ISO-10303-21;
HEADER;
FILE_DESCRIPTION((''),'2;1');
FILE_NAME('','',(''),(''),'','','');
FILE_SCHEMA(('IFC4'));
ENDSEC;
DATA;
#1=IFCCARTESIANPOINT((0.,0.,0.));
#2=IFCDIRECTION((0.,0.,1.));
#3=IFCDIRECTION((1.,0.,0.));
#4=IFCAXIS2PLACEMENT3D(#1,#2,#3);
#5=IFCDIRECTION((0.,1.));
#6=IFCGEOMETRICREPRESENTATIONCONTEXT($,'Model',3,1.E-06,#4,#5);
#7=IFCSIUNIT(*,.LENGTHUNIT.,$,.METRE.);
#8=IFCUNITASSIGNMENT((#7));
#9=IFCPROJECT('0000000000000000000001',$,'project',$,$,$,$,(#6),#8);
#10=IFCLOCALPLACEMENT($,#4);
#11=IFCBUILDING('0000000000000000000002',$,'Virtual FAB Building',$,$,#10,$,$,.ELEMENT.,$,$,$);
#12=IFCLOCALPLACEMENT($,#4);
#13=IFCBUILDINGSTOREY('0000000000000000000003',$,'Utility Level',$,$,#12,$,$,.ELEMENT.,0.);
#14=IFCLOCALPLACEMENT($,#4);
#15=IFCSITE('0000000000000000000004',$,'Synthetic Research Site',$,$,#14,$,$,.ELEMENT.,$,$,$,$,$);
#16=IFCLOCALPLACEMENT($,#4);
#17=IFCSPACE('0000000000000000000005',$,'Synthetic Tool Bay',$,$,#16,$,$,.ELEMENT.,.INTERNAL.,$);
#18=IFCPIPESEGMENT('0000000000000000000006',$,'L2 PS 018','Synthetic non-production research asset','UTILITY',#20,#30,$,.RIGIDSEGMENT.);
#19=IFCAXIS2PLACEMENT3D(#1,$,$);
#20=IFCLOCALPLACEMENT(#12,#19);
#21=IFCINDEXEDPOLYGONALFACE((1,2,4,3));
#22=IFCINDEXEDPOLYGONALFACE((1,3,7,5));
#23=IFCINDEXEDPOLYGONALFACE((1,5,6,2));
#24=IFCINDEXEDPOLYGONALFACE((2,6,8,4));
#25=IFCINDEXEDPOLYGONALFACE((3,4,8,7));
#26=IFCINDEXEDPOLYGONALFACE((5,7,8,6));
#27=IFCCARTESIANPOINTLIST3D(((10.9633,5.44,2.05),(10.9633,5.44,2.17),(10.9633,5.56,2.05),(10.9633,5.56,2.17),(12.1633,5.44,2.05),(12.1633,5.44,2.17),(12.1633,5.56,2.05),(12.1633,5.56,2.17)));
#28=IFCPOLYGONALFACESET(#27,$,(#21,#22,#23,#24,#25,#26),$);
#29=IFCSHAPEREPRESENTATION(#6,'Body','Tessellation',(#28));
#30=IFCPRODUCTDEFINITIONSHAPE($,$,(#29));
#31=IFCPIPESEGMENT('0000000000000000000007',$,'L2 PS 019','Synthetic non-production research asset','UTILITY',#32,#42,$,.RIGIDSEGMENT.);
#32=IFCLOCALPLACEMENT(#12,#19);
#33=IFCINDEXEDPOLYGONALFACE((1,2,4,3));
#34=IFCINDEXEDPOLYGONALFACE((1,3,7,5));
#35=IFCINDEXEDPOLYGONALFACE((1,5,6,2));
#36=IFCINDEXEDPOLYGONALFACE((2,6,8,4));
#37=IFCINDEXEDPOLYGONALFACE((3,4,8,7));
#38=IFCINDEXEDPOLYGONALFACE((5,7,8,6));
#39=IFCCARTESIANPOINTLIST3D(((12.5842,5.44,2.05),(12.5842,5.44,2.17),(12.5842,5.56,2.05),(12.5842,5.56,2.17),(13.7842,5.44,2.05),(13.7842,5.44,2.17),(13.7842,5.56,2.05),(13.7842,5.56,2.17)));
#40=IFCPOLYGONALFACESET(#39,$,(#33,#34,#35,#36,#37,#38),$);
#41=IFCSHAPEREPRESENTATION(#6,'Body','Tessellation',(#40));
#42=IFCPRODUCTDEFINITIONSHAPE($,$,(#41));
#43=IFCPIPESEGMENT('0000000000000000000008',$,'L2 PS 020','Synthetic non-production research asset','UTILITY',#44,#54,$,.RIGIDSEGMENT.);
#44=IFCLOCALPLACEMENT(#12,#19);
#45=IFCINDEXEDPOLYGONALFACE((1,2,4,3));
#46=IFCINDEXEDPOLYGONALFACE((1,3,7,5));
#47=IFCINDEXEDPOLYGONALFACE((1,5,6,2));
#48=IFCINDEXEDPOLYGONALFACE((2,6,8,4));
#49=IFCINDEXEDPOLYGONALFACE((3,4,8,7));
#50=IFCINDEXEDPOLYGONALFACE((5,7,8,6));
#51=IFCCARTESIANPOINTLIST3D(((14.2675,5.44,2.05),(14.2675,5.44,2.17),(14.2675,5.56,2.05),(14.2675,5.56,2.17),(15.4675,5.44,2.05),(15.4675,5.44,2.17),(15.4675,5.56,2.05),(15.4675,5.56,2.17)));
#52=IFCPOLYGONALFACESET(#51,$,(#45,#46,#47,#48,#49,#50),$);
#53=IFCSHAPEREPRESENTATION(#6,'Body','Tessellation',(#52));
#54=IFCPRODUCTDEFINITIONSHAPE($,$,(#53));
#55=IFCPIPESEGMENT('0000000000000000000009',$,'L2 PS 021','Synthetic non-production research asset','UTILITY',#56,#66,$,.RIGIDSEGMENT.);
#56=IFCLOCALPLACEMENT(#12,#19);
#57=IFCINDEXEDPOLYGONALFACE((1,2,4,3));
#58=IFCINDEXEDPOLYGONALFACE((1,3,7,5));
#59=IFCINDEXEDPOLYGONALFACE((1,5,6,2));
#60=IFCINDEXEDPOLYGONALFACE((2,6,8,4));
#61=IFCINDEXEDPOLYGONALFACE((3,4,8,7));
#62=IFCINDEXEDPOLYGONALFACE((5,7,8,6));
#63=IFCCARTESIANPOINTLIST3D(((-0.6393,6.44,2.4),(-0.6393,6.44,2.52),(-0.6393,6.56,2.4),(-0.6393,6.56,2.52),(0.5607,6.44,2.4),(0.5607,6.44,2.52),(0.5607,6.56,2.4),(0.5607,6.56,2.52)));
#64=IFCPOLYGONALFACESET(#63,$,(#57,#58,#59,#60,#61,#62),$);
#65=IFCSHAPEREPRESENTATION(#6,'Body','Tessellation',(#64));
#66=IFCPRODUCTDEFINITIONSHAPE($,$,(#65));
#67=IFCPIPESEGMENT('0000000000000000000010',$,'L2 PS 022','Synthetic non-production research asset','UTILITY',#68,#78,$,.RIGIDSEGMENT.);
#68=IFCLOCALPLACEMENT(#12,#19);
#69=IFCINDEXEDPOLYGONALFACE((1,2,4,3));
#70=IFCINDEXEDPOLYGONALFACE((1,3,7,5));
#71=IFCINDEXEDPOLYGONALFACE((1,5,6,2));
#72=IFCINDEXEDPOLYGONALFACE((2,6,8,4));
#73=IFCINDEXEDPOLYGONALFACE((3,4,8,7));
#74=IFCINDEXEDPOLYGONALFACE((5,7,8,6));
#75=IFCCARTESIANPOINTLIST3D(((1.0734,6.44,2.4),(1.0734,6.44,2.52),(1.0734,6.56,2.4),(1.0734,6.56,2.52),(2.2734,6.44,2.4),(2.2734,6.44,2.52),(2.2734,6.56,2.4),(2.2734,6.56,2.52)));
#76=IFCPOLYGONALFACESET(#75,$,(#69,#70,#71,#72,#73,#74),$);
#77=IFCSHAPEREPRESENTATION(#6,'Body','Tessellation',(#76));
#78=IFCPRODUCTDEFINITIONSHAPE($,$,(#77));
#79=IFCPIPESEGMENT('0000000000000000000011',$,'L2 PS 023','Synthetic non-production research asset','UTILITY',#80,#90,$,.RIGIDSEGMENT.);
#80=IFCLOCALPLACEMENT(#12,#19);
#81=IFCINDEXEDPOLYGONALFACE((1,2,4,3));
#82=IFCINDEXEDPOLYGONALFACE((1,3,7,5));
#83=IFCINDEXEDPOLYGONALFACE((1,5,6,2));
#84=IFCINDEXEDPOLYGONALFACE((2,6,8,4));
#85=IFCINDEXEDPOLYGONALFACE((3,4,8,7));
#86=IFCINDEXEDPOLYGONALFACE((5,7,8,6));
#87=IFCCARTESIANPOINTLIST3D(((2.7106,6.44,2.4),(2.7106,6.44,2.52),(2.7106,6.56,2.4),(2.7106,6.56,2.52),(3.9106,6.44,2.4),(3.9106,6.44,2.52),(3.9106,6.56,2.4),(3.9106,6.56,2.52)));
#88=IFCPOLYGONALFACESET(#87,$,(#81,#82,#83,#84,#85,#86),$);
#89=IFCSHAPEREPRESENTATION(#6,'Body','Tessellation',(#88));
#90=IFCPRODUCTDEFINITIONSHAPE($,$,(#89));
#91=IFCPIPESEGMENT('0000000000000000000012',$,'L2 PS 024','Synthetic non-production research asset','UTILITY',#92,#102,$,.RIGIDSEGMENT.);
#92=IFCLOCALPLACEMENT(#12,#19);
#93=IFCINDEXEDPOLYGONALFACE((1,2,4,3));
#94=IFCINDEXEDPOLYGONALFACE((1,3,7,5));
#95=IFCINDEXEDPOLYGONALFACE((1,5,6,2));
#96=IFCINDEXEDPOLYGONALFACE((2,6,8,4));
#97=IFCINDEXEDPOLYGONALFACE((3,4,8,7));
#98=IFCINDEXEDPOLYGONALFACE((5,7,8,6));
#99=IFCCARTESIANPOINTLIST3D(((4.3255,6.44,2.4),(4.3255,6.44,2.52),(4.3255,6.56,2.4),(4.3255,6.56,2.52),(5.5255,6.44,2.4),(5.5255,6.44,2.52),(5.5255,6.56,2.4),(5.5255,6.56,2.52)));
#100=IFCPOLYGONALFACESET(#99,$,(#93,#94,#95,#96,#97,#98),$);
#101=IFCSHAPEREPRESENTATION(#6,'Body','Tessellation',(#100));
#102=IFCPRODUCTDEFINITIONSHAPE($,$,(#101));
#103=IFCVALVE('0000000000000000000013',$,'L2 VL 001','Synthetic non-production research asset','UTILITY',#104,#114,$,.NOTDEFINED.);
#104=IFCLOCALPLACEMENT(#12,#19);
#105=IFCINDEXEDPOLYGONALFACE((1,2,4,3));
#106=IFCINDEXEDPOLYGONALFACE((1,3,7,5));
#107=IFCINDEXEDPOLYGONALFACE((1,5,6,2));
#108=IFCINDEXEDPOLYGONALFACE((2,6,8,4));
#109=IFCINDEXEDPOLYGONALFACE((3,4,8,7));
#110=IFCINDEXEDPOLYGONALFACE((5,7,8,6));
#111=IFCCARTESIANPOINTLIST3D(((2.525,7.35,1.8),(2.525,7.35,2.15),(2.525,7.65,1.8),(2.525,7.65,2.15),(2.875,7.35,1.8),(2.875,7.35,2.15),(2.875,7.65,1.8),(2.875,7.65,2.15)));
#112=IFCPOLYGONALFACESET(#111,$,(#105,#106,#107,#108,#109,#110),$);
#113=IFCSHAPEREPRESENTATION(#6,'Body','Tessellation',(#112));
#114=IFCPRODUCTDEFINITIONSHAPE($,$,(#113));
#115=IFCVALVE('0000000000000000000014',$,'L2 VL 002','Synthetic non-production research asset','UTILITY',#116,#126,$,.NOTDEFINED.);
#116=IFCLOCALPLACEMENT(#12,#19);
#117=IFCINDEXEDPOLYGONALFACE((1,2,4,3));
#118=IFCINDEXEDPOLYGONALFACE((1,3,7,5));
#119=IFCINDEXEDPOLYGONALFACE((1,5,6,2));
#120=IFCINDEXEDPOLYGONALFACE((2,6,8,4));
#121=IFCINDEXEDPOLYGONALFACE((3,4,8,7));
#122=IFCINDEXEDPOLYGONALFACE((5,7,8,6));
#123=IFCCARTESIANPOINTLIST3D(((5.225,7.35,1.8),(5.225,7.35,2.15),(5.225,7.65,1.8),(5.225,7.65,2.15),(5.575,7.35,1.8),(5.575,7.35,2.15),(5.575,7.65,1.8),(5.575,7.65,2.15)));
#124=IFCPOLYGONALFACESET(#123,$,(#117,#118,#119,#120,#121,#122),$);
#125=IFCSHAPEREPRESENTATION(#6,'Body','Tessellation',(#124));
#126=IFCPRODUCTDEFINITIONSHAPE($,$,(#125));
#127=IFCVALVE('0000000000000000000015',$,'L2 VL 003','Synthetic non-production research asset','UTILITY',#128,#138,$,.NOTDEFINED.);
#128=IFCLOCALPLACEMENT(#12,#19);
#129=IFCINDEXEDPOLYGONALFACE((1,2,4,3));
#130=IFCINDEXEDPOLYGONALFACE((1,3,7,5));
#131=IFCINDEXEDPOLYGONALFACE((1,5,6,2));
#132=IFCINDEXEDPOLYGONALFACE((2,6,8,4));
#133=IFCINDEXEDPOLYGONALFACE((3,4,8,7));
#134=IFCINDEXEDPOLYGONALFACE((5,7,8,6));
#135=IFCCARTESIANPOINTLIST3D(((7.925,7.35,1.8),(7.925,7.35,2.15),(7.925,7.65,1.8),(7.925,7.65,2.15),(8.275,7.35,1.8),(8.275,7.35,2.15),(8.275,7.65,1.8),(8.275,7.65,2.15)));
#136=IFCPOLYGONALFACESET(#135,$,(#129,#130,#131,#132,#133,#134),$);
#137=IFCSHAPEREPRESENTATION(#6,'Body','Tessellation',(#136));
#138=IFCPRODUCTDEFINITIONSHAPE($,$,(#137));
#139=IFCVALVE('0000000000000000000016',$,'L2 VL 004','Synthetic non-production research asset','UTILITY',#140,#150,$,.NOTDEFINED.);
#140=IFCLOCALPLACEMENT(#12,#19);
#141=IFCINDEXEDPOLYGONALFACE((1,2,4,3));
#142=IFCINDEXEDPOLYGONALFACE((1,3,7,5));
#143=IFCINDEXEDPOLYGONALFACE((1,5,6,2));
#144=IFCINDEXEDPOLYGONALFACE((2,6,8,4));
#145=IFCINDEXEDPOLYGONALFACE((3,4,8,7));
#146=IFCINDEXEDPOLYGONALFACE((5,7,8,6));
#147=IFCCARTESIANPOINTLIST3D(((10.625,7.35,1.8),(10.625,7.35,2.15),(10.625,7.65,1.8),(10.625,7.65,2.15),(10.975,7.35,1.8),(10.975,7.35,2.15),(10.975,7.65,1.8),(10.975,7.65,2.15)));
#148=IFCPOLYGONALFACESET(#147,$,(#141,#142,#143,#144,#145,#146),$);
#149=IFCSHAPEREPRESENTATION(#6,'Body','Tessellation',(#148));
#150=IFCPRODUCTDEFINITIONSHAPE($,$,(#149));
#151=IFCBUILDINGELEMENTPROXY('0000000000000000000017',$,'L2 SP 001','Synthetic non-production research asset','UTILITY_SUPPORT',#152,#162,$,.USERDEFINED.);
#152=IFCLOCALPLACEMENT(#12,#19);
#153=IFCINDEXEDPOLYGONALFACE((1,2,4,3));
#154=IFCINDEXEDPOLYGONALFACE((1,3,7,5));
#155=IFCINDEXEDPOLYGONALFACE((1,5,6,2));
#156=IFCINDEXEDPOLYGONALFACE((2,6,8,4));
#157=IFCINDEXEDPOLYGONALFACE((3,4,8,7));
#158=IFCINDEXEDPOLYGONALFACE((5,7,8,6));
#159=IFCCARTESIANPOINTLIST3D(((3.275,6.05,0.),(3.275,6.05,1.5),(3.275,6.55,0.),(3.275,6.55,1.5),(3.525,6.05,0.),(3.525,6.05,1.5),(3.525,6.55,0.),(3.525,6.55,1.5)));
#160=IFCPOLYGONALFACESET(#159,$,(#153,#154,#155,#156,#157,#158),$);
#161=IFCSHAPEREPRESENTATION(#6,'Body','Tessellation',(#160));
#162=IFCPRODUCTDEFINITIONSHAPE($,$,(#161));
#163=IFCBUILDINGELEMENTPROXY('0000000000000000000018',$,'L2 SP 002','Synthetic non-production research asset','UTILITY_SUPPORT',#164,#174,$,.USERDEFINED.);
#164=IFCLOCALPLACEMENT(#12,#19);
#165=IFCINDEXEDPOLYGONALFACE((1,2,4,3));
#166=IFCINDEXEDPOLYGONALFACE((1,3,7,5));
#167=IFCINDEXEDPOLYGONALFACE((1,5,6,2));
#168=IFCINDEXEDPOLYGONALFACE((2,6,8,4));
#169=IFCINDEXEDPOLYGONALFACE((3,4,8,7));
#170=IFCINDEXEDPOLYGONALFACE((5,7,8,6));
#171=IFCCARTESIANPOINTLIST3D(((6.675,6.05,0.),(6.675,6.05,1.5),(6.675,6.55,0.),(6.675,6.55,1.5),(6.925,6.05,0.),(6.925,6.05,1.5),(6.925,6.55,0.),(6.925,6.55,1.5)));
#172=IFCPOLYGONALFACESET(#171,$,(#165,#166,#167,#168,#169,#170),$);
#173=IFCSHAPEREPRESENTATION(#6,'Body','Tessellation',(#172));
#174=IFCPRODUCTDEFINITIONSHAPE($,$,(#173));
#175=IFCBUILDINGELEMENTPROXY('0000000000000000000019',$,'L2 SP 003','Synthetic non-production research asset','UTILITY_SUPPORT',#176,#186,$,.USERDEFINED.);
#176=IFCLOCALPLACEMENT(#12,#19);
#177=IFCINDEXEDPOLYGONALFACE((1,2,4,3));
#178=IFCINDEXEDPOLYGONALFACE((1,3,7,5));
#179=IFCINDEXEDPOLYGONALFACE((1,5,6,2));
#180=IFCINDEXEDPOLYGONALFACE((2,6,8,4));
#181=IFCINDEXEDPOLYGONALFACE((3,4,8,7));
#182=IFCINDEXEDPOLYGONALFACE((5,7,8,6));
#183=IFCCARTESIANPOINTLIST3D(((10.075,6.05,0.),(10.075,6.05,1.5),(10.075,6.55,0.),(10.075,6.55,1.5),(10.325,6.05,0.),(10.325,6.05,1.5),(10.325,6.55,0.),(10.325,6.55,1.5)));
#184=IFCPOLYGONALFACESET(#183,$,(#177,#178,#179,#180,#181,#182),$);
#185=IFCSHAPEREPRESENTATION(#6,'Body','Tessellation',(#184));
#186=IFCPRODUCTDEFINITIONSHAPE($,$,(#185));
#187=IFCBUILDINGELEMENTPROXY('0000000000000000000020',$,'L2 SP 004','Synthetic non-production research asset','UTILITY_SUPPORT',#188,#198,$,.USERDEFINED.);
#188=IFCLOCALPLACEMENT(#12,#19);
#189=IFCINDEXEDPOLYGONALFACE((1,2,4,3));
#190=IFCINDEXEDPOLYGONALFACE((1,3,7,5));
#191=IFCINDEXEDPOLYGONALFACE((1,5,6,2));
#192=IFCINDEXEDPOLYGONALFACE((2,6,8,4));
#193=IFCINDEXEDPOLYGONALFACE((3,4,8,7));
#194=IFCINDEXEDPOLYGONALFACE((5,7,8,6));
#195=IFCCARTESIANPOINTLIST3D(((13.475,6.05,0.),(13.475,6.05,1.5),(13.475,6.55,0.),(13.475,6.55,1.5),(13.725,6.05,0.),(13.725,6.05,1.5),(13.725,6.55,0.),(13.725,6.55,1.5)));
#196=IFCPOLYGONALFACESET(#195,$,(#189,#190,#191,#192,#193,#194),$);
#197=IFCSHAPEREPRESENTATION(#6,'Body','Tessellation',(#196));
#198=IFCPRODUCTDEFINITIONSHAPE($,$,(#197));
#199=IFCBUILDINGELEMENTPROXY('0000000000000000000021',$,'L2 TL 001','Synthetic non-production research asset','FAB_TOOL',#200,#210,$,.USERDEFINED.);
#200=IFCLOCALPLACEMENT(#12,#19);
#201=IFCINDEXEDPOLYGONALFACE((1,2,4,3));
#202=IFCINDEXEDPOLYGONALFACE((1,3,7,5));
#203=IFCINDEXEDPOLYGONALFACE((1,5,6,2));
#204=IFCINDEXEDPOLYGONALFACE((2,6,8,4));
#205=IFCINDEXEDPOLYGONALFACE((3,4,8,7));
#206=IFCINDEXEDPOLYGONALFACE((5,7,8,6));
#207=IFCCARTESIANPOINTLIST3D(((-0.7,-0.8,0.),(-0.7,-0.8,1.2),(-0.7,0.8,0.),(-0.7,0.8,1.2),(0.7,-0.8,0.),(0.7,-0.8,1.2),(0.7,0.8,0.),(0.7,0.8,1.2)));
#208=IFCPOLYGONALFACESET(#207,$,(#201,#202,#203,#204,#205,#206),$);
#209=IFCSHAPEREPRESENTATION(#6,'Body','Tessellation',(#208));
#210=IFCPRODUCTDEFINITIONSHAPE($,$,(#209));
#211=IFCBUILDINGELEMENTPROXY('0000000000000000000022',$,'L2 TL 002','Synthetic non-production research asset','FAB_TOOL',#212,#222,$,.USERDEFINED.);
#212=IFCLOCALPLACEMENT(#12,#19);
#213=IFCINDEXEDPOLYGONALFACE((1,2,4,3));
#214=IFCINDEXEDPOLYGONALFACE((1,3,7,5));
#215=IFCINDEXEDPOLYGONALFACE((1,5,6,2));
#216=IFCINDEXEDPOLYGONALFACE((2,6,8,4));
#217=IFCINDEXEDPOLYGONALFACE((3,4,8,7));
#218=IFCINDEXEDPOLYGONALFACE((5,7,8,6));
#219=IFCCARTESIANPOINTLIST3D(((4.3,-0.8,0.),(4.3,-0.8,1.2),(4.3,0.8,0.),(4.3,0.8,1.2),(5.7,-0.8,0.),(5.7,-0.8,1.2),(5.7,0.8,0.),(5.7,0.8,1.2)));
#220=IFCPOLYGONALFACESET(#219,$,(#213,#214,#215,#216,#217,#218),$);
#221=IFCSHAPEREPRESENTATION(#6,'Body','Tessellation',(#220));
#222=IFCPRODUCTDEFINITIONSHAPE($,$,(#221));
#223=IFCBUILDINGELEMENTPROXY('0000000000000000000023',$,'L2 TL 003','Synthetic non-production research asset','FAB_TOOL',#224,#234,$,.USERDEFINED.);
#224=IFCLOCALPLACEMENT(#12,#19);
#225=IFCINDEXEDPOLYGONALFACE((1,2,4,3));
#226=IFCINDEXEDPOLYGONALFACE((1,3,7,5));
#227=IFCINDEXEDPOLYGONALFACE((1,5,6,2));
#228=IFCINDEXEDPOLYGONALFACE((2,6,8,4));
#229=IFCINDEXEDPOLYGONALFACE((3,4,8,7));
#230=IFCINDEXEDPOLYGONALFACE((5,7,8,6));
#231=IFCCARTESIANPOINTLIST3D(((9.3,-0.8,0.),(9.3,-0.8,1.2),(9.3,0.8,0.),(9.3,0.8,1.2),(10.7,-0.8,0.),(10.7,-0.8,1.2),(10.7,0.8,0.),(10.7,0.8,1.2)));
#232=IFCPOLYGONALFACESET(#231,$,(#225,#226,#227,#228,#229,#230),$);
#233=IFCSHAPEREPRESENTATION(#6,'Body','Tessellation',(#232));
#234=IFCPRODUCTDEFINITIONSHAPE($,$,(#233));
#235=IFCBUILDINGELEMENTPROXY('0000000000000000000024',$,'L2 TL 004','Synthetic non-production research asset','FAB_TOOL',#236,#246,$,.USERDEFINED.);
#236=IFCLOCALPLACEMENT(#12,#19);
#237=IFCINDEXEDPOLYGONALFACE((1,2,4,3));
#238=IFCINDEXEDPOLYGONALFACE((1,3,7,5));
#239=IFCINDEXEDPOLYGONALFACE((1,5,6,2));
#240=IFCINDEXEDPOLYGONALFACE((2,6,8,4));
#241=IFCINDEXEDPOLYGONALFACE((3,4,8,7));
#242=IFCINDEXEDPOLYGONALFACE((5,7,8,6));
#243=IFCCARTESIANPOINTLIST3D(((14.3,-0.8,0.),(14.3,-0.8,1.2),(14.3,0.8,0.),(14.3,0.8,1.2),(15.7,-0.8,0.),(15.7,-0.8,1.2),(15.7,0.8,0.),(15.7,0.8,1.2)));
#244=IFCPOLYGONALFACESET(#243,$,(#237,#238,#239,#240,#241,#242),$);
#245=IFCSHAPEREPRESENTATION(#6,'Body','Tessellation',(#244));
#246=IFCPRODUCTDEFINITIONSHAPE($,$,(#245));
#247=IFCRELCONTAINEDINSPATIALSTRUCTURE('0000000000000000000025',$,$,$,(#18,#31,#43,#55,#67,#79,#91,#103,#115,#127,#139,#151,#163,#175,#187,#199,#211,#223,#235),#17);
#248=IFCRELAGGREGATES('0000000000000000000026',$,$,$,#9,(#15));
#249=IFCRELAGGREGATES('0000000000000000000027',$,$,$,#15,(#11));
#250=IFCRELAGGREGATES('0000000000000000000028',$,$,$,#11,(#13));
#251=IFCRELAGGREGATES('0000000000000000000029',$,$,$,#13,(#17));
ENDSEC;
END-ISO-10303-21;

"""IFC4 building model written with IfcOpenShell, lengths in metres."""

from ifc_helpers import new_model, si_unit, direction, frame, origin_with_axes, origin_2d_with_axis, place, context, project, spatial, rectangle, extrude, element, save


model = new_model("IFC4")

# Units and contexts
model_context = context("Model", 3, precision=1e-06, world=origin_with_axes(), true_north=direction((0.0, 1.0)))
ifc_project = project(units=[si_unit("LENGTHUNIT", "METRE")], contexts=[model_context])

# Site, building, storey, space
site_placement = place(None, origin_with_axes())
site = spatial("IfcSite", under=ifc_project, at=site_placement, Name="Synthetic Research Site", CompositionType="ELEMENT")
building_placement = place(None, origin_with_axes())
building = spatial("IfcBuilding", under=site, at=building_placement, Name="Virtual FAB Building", CompositionType="ELEMENT")
storey_placement = place(None, origin_with_axes())
storey = spatial("IfcBuildingStorey", under=building, at=storey_placement, Name="Utility Level", CompositionType="ELEMENT", Elevation=0.0)
space_placement = place(None, origin_with_axes())
space = spatial("IfcSpace", under=storey, at=space_placement, Name="Synthetic Tool Bay", CompositionType="ELEMENT", PredefinedType="INTERNAL")

# Pipe segments
for number, where, z_axis, x_axis, name in (
    (1, (11.5633, 5.5, 2.05), (0.0, 0.0, 1.0), (1.0, 0.0, 0.0), "L2 PS 018"),
    (2, (13.1842, 5.5, 2.05), (0.0, 0.0, 1.0), (1.0, 0.0, 0.0), "L2 PS 019"),
    (3, (14.8675, 5.5, 2.05), (0.0, 0.0, 1.0), (1.0, 0.0, 0.0), "L2 PS 020"),
    (4, (-0.0393, 6.5, 2.4), (0.0, 0.0, 1.0), (1.0, 0.0, 0.0), "L2 PS 021"),
    (5, (1.6734, 6.5, 2.4), (0.0, 0.0, 1.0), (1.0, 0.0, 0.0), "L2 PS 022"),
    (6, (3.3106, 6.5, 2.4), (0.0, 0.0, 1.0), (1.0, 0.0, 0.0), "L2 PS 023"),
    (7, (4.9255, 6.5, 2.4), (0.0, 0.0, 1.0), (1.0, 0.0, 0.0), "L2 PS 024"),
):
    element("IfcPipeSegment", number, at=place(None, frame(where, z_axis=z_axis, x_axis=x_axis)), inside=space, Name=name, Description="Synthetic non-production research asset", ObjectType="UTILITY", PredefinedType="RIGIDSEGMENT", context=model_context, shape_type="SweptSolid", body=[
        extrude(rectangle(XDim=1.2, YDim=0.12, at=origin_2d_with_axis()), origin_with_axes(), (0.0, 0.0, 1.0), 0.12),
    ])

# Valves
for number, where, z_axis, x_axis, name in (
    (8, (2.7, 7.5, 1.8), (0.0, 0.0, 1.0), (1.0, 0.0, 0.0), "L2 VL 001"),
    (9, (5.4, 7.5, 1.8), (0.0, 0.0, 1.0), (1.0, 0.0, 0.0), "L2 VL 002"),
    (10, (8.1, 7.5, 1.8), (0.0, 0.0, 1.0), (1.0, 0.0, 0.0), "L2 VL 003"),
    (11, (10.8, 7.5, 1.8), (0.0, 0.0, 1.0), (1.0, 0.0, 0.0), "L2 VL 004"),
):
    element("IfcValve", number, at=place(None, frame(where, z_axis=z_axis, x_axis=x_axis)), inside=space, Name=name, Description="Synthetic non-production research asset", ObjectType="UTILITY", PredefinedType="NOTDEFINED", context=model_context, shape_type="SweptSolid", body=[
        extrude(rectangle(XDim=0.35, YDim=0.3, at=origin_2d_with_axis()), origin_with_axes(), (0.0, 0.0, 1.0), 0.35),
    ])

# Building element proxies
for number, where, z_axis, x_axis, name in (
    (12, (3.4, 6.3, 0.0), (0.0, 0.0, 1.0), (1.0, 0.0, 0.0), "L2 SP 001"),
    (13, (6.8, 6.3, 0.0), (0.0, 0.0, 1.0), (1.0, 0.0, 0.0), "L2 SP 002"),
    (14, (10.2, 6.3, 0.0), (0.0, 0.0, 1.0), (1.0, 0.0, 0.0), "L2 SP 003"),
    (15, (13.6, 6.3, 0.0), (0.0, 0.0, 1.0), (1.0, 0.0, 0.0), "L2 SP 004"),
):
    element("IfcBuildingElementProxy", number, at=place(None, frame(where, z_axis=z_axis, x_axis=x_axis)), inside=space, Name=name, Description="Synthetic non-production research asset", ObjectType="UTILITY_SUPPORT", PredefinedType="USERDEFINED", context=model_context, shape_type="SweptSolid", body=[
        extrude(rectangle(XDim=0.25, YDim=0.5, at=origin_2d_with_axis()), origin_with_axes(), (0.0, 0.0, 1.0), 1.5),
    ])
for number, where, z_axis, x_axis, name in (
    (16, (0.0, 0.0, 0.0), (0.0, 0.0, 1.0), (1.0, 0.0, 0.0), "L2 TL 001"),
    (17, (5.0, 0.0, 0.0), (0.0, 0.0, 1.0), (1.0, 0.0, 0.0), "L2 TL 002"),
    (18, (10.0, 0.0, 0.0), (0.0, 0.0, 1.0), (1.0, 0.0, 0.0), "L2 TL 003"),
    (19, (15.0, 0.0, 0.0), (0.0, 0.0, 1.0), (1.0, 0.0, 0.0), "L2 TL 004"),
):
    element("IfcBuildingElementProxy", number, at=place(None, frame(where, z_axis=z_axis, x_axis=x_axis)), inside=space, Name=name, Description="Synthetic non-production research asset", ObjectType="FAB_TOOL", PredefinedType="USERDEFINED", context=model_context, shape_type="SweptSolid", body=[
        extrude(rectangle(XDim=1.4, YDim=1.6, at=origin_2d_with_axis()), origin_with_axes(), (0.0, 0.0, 1.0), 1.2),
    ])

save(model, "model.ifc")
